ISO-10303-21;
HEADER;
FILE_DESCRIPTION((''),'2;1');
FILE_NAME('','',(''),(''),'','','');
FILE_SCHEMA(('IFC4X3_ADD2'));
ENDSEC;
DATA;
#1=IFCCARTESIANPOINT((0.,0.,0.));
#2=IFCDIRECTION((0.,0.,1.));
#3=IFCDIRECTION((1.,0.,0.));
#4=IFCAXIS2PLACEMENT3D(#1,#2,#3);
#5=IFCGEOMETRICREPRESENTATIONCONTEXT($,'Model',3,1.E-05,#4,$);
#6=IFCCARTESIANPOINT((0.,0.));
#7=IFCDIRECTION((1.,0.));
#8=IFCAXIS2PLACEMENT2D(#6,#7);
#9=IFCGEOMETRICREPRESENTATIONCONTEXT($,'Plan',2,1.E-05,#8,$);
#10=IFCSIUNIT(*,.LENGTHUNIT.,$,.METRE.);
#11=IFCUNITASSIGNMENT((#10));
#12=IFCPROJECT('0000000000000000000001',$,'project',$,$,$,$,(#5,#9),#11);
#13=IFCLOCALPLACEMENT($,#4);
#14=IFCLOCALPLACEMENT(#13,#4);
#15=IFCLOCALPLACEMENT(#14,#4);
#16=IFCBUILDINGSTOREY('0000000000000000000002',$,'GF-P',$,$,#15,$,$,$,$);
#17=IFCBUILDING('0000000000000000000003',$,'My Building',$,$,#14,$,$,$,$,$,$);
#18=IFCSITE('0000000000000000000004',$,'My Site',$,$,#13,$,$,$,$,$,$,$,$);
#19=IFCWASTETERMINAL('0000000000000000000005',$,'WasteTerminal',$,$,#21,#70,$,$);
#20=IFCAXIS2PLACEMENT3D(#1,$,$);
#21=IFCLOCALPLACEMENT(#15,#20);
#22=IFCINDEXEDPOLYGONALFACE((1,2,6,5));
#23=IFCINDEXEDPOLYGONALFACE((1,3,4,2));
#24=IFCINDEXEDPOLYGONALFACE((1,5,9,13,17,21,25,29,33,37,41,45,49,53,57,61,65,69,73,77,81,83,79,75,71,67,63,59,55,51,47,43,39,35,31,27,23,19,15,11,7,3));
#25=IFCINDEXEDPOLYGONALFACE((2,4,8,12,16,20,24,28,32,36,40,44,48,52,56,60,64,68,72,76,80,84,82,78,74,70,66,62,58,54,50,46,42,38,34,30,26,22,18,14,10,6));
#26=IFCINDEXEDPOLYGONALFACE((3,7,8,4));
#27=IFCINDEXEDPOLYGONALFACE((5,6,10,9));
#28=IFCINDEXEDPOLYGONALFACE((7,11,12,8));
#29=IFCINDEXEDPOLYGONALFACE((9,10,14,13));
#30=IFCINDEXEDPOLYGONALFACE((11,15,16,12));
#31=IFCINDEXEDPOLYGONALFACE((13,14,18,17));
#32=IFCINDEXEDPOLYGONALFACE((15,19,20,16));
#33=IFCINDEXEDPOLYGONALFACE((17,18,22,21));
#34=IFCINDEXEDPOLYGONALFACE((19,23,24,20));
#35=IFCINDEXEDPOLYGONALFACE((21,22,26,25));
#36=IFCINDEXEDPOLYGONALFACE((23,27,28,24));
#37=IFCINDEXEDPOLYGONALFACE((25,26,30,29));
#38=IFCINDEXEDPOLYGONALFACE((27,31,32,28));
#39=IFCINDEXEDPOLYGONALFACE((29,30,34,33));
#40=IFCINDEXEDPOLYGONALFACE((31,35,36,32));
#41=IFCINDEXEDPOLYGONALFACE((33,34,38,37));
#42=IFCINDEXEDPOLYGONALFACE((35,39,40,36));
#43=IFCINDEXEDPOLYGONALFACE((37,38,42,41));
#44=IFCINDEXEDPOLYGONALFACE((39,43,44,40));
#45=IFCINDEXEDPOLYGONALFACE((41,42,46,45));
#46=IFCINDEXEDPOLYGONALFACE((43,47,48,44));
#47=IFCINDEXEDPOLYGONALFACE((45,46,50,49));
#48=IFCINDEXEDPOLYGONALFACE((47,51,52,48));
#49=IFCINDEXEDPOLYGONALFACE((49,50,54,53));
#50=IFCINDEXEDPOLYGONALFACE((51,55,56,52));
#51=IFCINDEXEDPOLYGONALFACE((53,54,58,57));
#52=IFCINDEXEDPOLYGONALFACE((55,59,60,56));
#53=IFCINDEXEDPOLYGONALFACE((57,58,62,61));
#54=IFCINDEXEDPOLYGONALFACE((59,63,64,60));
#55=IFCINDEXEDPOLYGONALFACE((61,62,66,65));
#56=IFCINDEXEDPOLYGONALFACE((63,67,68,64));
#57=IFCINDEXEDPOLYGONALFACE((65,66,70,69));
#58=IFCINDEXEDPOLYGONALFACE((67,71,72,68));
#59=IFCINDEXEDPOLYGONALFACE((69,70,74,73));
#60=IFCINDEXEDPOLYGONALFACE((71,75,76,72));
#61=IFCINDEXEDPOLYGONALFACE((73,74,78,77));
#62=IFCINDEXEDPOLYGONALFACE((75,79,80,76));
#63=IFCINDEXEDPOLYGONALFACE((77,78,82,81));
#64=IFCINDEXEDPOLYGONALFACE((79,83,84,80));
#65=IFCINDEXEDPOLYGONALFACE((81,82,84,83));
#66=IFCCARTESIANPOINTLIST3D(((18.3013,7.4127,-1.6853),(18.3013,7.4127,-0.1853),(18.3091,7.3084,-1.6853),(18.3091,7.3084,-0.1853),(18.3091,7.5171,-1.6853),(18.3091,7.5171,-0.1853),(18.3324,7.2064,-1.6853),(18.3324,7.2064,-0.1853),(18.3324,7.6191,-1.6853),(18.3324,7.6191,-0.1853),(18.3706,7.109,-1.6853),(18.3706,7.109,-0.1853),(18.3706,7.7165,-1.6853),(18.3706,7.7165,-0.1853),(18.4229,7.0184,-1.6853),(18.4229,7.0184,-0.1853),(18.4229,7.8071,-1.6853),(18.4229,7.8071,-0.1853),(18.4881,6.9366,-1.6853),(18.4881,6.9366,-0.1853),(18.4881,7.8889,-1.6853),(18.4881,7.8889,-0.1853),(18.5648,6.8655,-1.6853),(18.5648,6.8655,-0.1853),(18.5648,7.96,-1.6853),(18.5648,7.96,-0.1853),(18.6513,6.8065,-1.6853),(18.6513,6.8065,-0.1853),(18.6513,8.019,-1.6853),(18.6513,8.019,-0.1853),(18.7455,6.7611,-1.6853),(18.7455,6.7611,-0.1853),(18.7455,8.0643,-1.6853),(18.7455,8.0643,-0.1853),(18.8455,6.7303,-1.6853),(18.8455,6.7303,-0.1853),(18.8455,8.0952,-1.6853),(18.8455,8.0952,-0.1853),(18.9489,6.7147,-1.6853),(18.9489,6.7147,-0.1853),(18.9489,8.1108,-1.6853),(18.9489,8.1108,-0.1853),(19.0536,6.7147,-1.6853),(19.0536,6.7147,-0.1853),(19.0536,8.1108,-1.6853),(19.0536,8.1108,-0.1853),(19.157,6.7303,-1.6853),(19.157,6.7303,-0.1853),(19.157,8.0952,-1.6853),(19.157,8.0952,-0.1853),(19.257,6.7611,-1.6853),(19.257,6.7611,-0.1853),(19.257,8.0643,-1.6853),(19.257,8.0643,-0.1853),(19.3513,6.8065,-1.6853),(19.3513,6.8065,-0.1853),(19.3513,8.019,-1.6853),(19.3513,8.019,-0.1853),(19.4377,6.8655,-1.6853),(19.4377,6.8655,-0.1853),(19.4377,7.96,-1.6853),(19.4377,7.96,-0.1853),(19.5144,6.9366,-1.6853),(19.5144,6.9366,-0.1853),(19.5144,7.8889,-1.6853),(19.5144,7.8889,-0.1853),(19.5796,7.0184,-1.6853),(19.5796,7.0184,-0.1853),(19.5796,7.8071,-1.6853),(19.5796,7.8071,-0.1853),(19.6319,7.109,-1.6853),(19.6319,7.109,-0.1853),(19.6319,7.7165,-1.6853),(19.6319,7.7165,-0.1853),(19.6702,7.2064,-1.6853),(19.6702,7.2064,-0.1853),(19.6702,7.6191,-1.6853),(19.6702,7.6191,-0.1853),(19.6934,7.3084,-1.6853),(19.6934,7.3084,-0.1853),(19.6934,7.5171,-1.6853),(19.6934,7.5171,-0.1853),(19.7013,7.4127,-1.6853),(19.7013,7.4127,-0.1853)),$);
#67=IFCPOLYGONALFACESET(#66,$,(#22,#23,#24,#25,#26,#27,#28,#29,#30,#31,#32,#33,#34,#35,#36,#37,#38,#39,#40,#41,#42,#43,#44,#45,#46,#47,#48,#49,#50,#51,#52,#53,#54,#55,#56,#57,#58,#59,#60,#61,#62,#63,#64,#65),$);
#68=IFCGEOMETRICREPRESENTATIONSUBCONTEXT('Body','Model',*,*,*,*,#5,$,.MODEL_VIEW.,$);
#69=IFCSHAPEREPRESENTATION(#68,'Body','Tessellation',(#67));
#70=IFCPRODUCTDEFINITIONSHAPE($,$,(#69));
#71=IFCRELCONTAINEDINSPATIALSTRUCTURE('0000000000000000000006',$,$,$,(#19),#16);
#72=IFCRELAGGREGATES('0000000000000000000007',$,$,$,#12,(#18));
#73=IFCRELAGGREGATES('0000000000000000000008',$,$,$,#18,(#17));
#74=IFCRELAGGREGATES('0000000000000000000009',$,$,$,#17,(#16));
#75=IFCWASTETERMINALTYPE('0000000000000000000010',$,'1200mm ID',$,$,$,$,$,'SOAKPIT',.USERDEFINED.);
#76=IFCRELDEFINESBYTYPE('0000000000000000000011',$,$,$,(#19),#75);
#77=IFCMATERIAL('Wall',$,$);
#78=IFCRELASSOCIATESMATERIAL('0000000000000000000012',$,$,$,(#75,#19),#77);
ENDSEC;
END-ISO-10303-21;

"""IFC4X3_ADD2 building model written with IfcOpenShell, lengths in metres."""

from ifc_helpers import new_model, si_unit, frame, origin_with_axes, origin_2d_with_axis, place, context, subcontext, project, spatial, circle, extrude, material, material_profile, profile_set, profile_usage, type_object, element, save


model = new_model("IFC4X3_ADD2")

# Units and contexts
model_context = context("Model", 3, precision=1e-05, world=origin_with_axes())
plan_context = context("Plan", 2, precision=1e-05, world=origin_2d_with_axis())
body_context = subcontext(model_context, "Body", "Model", "MODEL_VIEW")
ifc_project = project(units=[si_unit("LENGTHUNIT", "METRE")], contexts=[model_context, plan_context])

# Site, building, storey
site_placement = place(None, origin_with_axes())
site = spatial("IfcSite", under=ifc_project, at=site_placement, Name="My Site")
building_placement = place(site_placement, origin_with_axes())
building = spatial("IfcBuilding", under=site, at=building_placement, Name="My Building")
storey_placement = place(building_placement, origin_with_axes())
storey = spatial("IfcBuildingStorey", under=building, at=storey_placement, Name="GF-P")

# Shared definitions
ifc_material_1 = material(Name="Wall")

# Waste terminal
ifc_material_profile_1 = material_profile(ifc_material_1, circle(Radius=0.7))
ifc_profile_set_1 = profile_set([ifc_material_profile_1])
ifc_profile_usage_1 = profile_usage(ifc_profile_set_1, cardinal=5)
waste_terminal_type = type_object("IfcWasteTerminalType", Name="1200mm ID", ElementType="SOAKPIT", PredefinedType="USERDEFINED", material=ifc_profile_set_1)
waste_terminal_placement = place(storey_placement, frame((19.0013, 7.4127, -0.1853), z_axis=(0.0, 0.0, -1.0), x_axis=(-1.0, 0.0, 0.0)))
element("IfcWasteTerminal", 1, at=waste_terminal_placement, inside=storey, type_object=waste_terminal_type, material=ifc_profile_usage_1, Name="WasteTerminal", context=body_context, shape_type="SweptSolid", body=[
    extrude(circle(Radius=0.7), origin_with_axes(), (0.0, 0.0, 1.0), 1.5),
])

save(model, "model.ifc")
